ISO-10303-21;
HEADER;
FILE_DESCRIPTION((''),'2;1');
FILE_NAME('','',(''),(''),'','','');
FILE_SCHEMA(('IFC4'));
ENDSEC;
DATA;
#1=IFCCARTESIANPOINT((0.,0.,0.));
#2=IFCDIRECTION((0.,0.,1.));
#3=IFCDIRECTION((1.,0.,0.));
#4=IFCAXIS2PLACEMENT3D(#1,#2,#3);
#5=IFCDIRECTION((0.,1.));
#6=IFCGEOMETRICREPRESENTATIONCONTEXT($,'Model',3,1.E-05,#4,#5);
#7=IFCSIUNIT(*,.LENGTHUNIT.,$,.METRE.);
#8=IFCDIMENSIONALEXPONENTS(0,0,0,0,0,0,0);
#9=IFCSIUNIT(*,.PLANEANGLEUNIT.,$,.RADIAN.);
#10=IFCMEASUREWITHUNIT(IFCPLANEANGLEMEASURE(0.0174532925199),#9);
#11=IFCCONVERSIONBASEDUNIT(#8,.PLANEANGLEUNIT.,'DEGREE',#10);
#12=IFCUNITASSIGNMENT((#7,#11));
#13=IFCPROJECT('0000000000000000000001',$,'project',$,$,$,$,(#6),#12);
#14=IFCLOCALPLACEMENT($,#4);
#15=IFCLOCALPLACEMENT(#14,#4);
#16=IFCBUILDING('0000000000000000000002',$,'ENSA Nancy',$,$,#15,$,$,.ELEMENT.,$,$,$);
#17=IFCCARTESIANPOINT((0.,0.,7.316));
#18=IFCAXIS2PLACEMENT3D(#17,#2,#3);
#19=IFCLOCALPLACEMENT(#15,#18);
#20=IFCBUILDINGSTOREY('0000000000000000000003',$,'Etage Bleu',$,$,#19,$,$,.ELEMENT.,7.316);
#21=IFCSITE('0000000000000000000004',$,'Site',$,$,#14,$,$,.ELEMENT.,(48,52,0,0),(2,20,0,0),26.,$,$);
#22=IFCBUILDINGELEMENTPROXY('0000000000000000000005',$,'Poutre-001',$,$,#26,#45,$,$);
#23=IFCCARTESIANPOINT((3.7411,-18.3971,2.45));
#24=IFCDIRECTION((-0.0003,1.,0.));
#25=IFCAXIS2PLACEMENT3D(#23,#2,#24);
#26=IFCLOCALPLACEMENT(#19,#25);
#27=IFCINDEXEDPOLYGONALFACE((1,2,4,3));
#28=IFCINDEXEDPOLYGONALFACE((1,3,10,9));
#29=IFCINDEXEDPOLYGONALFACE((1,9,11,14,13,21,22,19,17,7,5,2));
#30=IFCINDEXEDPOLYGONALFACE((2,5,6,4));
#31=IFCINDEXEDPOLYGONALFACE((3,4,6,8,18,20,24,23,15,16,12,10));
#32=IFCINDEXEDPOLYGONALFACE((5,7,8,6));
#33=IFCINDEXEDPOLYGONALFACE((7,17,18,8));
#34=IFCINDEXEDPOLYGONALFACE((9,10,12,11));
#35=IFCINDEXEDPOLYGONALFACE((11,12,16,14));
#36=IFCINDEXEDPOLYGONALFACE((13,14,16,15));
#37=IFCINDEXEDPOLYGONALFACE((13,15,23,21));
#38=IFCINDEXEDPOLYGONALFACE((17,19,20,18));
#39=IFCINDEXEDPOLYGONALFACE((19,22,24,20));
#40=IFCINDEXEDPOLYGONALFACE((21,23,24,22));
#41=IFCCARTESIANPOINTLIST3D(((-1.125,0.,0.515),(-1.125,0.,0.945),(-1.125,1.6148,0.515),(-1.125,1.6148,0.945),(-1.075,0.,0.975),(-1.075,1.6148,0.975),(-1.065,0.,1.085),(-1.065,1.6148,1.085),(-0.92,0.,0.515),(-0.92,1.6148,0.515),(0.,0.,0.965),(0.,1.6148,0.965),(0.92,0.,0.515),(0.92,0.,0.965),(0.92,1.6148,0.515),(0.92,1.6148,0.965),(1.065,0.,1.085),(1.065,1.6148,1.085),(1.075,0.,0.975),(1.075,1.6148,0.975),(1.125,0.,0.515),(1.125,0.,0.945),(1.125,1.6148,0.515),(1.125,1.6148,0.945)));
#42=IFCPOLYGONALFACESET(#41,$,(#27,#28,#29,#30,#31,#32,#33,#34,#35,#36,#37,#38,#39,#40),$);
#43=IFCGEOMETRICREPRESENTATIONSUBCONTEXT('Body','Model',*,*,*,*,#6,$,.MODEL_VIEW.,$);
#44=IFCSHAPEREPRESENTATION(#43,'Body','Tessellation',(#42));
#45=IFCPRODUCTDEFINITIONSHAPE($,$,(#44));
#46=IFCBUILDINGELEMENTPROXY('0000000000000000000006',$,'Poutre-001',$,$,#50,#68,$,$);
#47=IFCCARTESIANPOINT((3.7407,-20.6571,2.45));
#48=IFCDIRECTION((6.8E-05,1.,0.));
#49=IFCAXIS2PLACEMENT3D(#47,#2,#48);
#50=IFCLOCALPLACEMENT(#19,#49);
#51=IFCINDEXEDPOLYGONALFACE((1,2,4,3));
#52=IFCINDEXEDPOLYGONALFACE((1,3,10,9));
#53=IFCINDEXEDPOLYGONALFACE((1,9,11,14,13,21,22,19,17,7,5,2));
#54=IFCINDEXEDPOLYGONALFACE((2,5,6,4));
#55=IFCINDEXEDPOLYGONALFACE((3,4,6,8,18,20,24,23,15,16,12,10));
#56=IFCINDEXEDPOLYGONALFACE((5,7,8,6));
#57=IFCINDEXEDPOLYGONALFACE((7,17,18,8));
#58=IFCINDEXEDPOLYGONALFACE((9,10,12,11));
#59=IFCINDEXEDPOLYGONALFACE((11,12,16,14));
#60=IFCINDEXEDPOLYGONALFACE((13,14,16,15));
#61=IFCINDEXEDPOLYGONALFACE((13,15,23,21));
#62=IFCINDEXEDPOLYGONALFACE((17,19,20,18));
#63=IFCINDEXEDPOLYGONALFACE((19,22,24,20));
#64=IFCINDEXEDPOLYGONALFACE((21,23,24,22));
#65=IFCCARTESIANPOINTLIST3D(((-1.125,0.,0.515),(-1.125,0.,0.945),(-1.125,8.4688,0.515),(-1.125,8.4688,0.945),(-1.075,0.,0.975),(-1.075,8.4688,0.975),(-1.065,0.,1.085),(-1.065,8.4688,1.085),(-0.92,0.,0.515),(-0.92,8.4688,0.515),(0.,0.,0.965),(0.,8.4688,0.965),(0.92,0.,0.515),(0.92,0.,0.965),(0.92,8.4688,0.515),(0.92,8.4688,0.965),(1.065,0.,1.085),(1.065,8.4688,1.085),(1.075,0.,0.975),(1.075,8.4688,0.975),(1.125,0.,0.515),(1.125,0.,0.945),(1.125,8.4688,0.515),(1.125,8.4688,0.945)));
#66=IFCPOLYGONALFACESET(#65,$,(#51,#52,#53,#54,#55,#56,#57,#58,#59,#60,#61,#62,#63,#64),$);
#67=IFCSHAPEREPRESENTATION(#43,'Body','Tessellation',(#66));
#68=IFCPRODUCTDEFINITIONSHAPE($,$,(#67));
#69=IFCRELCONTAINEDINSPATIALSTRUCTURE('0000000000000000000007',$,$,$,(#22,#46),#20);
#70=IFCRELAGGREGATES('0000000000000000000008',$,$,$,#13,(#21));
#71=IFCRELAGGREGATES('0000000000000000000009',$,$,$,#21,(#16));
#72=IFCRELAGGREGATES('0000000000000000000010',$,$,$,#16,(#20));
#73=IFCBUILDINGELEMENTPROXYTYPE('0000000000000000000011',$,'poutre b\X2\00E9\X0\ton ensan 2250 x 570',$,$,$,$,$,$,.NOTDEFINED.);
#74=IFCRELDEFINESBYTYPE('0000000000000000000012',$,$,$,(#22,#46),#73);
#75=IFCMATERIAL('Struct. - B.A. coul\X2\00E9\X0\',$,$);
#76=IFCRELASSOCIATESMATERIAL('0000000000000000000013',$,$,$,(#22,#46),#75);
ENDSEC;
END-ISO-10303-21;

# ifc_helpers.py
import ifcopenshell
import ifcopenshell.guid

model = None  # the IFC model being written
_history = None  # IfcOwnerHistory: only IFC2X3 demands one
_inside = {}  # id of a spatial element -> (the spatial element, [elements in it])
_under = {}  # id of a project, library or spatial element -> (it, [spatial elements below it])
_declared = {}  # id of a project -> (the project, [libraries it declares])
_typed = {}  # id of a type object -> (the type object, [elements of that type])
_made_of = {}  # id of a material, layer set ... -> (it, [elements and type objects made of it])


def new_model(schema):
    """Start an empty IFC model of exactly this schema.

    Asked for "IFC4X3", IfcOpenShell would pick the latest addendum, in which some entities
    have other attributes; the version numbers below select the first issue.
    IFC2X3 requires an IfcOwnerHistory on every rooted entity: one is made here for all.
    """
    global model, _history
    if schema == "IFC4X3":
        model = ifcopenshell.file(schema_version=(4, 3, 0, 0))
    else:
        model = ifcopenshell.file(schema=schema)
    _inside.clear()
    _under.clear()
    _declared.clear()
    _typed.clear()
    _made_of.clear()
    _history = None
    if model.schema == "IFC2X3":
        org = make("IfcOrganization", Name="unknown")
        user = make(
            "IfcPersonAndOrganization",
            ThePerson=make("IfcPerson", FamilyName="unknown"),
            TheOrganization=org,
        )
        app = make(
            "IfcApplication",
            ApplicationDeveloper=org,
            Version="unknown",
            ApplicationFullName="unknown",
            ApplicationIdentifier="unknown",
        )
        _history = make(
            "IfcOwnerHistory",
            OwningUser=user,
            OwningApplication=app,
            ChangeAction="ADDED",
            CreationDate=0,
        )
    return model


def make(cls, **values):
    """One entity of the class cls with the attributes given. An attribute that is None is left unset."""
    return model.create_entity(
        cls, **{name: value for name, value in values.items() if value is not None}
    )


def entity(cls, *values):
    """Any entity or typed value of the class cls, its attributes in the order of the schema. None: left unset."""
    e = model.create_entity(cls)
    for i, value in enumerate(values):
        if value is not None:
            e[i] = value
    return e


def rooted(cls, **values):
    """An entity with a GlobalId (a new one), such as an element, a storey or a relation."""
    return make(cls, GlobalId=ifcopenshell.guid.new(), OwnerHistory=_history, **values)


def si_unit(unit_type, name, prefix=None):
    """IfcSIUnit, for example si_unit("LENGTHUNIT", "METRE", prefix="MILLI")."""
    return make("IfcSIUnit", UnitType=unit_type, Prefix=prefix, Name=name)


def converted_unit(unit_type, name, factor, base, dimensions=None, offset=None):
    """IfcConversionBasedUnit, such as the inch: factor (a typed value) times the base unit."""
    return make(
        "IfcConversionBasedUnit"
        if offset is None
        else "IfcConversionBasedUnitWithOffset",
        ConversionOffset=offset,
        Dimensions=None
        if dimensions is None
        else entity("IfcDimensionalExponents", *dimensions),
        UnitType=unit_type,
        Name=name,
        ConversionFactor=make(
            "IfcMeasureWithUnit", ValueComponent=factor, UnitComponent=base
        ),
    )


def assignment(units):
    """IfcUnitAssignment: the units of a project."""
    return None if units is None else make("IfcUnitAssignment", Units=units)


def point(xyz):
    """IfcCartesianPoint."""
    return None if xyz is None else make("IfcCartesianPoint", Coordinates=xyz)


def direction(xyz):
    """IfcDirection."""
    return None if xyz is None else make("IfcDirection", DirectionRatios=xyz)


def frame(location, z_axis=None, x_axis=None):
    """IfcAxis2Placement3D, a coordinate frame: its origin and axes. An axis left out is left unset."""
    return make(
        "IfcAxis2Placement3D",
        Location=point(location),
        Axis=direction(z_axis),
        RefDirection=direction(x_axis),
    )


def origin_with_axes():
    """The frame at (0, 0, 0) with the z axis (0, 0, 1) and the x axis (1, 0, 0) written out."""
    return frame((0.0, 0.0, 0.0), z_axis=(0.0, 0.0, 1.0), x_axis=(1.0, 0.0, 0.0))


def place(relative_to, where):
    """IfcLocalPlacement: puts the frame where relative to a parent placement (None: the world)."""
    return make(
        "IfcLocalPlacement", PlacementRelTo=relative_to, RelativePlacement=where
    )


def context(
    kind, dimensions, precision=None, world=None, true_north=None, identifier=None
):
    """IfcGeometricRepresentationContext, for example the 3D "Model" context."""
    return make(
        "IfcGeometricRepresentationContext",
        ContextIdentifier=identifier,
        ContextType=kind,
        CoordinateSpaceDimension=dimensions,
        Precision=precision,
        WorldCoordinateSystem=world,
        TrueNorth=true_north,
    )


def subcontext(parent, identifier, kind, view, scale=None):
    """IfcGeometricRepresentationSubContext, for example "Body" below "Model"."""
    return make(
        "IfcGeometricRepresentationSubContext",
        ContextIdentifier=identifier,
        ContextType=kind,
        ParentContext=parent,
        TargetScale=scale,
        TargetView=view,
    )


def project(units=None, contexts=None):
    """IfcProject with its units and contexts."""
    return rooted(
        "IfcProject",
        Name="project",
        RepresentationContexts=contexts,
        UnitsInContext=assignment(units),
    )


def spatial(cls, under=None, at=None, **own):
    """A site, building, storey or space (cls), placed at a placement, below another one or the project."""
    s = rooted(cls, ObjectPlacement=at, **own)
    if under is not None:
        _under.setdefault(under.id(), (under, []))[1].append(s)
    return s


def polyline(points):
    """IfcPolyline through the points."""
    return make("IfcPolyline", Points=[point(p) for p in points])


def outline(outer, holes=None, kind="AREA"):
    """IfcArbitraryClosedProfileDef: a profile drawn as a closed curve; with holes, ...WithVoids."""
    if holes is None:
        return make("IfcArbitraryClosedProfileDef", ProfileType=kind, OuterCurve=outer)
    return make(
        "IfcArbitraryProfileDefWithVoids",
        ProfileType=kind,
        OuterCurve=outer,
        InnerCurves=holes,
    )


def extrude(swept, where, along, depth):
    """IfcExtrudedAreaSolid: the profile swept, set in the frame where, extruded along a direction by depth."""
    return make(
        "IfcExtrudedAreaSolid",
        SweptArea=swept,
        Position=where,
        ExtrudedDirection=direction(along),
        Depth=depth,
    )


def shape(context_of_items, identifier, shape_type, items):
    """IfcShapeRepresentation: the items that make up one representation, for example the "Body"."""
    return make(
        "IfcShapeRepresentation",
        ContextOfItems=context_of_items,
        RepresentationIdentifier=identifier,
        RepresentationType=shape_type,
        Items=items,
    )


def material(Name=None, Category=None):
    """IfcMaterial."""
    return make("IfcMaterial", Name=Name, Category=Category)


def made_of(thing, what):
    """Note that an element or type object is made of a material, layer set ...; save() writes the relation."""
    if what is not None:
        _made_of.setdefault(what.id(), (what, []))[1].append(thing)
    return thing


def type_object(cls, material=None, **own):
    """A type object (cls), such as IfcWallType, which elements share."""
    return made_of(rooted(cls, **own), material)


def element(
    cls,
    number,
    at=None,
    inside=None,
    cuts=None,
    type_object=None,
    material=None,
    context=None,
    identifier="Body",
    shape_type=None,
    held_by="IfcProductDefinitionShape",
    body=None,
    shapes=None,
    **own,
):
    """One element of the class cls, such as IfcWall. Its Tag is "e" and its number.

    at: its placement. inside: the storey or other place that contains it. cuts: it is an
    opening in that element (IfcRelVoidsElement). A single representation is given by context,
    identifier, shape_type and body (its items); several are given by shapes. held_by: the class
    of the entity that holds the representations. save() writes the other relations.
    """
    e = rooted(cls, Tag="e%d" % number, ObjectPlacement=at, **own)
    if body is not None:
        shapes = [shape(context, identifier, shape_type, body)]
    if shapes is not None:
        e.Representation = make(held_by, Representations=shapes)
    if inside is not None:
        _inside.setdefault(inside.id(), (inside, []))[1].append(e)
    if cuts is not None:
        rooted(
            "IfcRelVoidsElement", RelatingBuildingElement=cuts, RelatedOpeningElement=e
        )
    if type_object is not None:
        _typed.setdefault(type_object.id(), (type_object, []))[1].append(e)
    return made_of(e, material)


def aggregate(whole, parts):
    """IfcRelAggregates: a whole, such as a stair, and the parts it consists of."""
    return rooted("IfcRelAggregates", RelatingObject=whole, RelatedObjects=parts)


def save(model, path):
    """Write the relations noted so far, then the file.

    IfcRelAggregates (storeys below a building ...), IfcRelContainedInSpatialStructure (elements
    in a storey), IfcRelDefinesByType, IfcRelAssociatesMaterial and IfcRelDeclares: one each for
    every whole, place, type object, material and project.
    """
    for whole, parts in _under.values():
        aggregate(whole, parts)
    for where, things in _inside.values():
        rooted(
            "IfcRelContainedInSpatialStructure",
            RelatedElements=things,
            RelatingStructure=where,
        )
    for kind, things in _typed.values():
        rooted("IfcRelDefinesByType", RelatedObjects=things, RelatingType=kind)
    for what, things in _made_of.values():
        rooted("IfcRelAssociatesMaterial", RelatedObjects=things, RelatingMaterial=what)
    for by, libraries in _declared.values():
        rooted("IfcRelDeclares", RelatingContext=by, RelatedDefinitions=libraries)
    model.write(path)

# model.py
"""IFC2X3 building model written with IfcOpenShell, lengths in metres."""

from ifc_helpers import new_model, entity, si_unit, converted_unit, direction, frame, origin_with_axes, place, context, subcontext, project, spatial, polyline, outline, extrude, material, type_object, element, save


model = new_model("IFC2X3")

# Units and contexts
model_context = context("Model", 3, precision=1e-05, world=origin_with_axes(), true_north=direction((0.0, 1.0)))
body_context = subcontext(model_context, "Body", "Model", "MODEL_VIEW")
ifc_project = project(units=[si_unit("LENGTHUNIT", "METRE"), converted_unit("PLANEANGLEUNIT", "DEGREE", entity("IfcPlaneAngleMeasure", 0.0174532925199), si_unit("PLANEANGLEUNIT", "RADIAN"), dimensions=[0, 0, 0, 0, 0, 0, 0])], contexts=[model_context])

# Site, building, storey
site_placement = place(None, origin_with_axes())
site = spatial("IfcSite", under=ifc_project, at=site_placement, Name="Site", CompositionType="ELEMENT", RefLatitude=(48, 52, 0, 0), RefLongitude=(2, 20, 0, 0), RefElevation=26.0)
building_placement = place(site_placement, origin_with_axes())
building = spatial("IfcBuilding", under=site, at=building_placement, Name="ENSA Nancy", CompositionType="ELEMENT")
storey_placement = place(building_placement, frame((0.0, 0.0, 7.316), z_axis=(0.0, 0.0, 1.0), x_axis=(1.0, 0.0, 0.0)))
storey = spatial("IfcBuildingStorey", under=building, at=storey_placement, Name="Etage Bleu", CompositionType="ELEMENT", Elevation=7.316)

# Building element proxies
ifc_material_1 = material(Name="Struct. - B.A. coulé")
building_element_proxy_type_1 = type_object("IfcBuildingElementProxyType", Name="poutre béton ensan 2250 x 570", PredefinedType="NOTDEFINED")
proxy_1_placement = place(storey_placement, frame((3.7411, -18.3971, 2.45), z_axis=(0.0, 0.0, 1.0), x_axis=(-0.0003, 1.0, 0.0)))
element("IfcBuildingElementProxy", 1, at=proxy_1_placement, inside=storey, type_object=building_element_proxy_type_1, material=ifc_material_1, Name="Poutre-001", context=body_context, shape_type="SweptSolid", body=[
    extrude(outline(polyline([(-1.065, 1.085), (-1.075, 0.975), (-1.125, 0.945), (-1.125, 0.515), (-0.92, 0.515), (0.0, 0.965), (0.92, 0.965), (0.92, 0.515), (1.125, 0.515), (1.125, 0.945), (1.075, 0.975), (1.065, 1.085), (-1.065, 1.085)])), frame((0.0, 1.6148, 0.0), z_axis=(0.0, -1.0, 0.0), x_axis=(1.0, 0.0, 0.0)), (0.0, 0.0, 1.0), 1.6148),
])
proxy_2_placement = place(storey_placement, frame((3.7407, -20.6571, 2.45), z_axis=(0.0, 0.0, 1.0), x_axis=(0.000068, 1.0, 0.0)))
element("IfcBuildingElementProxy", 2, at=proxy_2_placement, inside=storey, type_object=building_element_proxy_type_1, material=ifc_material_1, Name="Poutre-001", context=body_context, shape_type="SweptSolid", body=[
    extrude(outline(polyline([(-1.065, 1.085), (-1.075, 0.975), (-1.125, 0.945), (-1.125, 0.515), (-0.92, 0.515), (0.0, 0.965), (0.92, 0.965), (0.92, 0.515), (1.125, 0.515), (1.125, 0.945), (1.075, 0.975), (1.065, 1.085), (-1.065, 1.085)])), frame((0.0, 8.4688, 0.0), z_axis=(0.0, -1.0, 0.0), x_axis=(1.0, 0.0, 0.0)), (0.0, 0.0, 1.0), 8.4688),
])

save(model, "model.ifc")
